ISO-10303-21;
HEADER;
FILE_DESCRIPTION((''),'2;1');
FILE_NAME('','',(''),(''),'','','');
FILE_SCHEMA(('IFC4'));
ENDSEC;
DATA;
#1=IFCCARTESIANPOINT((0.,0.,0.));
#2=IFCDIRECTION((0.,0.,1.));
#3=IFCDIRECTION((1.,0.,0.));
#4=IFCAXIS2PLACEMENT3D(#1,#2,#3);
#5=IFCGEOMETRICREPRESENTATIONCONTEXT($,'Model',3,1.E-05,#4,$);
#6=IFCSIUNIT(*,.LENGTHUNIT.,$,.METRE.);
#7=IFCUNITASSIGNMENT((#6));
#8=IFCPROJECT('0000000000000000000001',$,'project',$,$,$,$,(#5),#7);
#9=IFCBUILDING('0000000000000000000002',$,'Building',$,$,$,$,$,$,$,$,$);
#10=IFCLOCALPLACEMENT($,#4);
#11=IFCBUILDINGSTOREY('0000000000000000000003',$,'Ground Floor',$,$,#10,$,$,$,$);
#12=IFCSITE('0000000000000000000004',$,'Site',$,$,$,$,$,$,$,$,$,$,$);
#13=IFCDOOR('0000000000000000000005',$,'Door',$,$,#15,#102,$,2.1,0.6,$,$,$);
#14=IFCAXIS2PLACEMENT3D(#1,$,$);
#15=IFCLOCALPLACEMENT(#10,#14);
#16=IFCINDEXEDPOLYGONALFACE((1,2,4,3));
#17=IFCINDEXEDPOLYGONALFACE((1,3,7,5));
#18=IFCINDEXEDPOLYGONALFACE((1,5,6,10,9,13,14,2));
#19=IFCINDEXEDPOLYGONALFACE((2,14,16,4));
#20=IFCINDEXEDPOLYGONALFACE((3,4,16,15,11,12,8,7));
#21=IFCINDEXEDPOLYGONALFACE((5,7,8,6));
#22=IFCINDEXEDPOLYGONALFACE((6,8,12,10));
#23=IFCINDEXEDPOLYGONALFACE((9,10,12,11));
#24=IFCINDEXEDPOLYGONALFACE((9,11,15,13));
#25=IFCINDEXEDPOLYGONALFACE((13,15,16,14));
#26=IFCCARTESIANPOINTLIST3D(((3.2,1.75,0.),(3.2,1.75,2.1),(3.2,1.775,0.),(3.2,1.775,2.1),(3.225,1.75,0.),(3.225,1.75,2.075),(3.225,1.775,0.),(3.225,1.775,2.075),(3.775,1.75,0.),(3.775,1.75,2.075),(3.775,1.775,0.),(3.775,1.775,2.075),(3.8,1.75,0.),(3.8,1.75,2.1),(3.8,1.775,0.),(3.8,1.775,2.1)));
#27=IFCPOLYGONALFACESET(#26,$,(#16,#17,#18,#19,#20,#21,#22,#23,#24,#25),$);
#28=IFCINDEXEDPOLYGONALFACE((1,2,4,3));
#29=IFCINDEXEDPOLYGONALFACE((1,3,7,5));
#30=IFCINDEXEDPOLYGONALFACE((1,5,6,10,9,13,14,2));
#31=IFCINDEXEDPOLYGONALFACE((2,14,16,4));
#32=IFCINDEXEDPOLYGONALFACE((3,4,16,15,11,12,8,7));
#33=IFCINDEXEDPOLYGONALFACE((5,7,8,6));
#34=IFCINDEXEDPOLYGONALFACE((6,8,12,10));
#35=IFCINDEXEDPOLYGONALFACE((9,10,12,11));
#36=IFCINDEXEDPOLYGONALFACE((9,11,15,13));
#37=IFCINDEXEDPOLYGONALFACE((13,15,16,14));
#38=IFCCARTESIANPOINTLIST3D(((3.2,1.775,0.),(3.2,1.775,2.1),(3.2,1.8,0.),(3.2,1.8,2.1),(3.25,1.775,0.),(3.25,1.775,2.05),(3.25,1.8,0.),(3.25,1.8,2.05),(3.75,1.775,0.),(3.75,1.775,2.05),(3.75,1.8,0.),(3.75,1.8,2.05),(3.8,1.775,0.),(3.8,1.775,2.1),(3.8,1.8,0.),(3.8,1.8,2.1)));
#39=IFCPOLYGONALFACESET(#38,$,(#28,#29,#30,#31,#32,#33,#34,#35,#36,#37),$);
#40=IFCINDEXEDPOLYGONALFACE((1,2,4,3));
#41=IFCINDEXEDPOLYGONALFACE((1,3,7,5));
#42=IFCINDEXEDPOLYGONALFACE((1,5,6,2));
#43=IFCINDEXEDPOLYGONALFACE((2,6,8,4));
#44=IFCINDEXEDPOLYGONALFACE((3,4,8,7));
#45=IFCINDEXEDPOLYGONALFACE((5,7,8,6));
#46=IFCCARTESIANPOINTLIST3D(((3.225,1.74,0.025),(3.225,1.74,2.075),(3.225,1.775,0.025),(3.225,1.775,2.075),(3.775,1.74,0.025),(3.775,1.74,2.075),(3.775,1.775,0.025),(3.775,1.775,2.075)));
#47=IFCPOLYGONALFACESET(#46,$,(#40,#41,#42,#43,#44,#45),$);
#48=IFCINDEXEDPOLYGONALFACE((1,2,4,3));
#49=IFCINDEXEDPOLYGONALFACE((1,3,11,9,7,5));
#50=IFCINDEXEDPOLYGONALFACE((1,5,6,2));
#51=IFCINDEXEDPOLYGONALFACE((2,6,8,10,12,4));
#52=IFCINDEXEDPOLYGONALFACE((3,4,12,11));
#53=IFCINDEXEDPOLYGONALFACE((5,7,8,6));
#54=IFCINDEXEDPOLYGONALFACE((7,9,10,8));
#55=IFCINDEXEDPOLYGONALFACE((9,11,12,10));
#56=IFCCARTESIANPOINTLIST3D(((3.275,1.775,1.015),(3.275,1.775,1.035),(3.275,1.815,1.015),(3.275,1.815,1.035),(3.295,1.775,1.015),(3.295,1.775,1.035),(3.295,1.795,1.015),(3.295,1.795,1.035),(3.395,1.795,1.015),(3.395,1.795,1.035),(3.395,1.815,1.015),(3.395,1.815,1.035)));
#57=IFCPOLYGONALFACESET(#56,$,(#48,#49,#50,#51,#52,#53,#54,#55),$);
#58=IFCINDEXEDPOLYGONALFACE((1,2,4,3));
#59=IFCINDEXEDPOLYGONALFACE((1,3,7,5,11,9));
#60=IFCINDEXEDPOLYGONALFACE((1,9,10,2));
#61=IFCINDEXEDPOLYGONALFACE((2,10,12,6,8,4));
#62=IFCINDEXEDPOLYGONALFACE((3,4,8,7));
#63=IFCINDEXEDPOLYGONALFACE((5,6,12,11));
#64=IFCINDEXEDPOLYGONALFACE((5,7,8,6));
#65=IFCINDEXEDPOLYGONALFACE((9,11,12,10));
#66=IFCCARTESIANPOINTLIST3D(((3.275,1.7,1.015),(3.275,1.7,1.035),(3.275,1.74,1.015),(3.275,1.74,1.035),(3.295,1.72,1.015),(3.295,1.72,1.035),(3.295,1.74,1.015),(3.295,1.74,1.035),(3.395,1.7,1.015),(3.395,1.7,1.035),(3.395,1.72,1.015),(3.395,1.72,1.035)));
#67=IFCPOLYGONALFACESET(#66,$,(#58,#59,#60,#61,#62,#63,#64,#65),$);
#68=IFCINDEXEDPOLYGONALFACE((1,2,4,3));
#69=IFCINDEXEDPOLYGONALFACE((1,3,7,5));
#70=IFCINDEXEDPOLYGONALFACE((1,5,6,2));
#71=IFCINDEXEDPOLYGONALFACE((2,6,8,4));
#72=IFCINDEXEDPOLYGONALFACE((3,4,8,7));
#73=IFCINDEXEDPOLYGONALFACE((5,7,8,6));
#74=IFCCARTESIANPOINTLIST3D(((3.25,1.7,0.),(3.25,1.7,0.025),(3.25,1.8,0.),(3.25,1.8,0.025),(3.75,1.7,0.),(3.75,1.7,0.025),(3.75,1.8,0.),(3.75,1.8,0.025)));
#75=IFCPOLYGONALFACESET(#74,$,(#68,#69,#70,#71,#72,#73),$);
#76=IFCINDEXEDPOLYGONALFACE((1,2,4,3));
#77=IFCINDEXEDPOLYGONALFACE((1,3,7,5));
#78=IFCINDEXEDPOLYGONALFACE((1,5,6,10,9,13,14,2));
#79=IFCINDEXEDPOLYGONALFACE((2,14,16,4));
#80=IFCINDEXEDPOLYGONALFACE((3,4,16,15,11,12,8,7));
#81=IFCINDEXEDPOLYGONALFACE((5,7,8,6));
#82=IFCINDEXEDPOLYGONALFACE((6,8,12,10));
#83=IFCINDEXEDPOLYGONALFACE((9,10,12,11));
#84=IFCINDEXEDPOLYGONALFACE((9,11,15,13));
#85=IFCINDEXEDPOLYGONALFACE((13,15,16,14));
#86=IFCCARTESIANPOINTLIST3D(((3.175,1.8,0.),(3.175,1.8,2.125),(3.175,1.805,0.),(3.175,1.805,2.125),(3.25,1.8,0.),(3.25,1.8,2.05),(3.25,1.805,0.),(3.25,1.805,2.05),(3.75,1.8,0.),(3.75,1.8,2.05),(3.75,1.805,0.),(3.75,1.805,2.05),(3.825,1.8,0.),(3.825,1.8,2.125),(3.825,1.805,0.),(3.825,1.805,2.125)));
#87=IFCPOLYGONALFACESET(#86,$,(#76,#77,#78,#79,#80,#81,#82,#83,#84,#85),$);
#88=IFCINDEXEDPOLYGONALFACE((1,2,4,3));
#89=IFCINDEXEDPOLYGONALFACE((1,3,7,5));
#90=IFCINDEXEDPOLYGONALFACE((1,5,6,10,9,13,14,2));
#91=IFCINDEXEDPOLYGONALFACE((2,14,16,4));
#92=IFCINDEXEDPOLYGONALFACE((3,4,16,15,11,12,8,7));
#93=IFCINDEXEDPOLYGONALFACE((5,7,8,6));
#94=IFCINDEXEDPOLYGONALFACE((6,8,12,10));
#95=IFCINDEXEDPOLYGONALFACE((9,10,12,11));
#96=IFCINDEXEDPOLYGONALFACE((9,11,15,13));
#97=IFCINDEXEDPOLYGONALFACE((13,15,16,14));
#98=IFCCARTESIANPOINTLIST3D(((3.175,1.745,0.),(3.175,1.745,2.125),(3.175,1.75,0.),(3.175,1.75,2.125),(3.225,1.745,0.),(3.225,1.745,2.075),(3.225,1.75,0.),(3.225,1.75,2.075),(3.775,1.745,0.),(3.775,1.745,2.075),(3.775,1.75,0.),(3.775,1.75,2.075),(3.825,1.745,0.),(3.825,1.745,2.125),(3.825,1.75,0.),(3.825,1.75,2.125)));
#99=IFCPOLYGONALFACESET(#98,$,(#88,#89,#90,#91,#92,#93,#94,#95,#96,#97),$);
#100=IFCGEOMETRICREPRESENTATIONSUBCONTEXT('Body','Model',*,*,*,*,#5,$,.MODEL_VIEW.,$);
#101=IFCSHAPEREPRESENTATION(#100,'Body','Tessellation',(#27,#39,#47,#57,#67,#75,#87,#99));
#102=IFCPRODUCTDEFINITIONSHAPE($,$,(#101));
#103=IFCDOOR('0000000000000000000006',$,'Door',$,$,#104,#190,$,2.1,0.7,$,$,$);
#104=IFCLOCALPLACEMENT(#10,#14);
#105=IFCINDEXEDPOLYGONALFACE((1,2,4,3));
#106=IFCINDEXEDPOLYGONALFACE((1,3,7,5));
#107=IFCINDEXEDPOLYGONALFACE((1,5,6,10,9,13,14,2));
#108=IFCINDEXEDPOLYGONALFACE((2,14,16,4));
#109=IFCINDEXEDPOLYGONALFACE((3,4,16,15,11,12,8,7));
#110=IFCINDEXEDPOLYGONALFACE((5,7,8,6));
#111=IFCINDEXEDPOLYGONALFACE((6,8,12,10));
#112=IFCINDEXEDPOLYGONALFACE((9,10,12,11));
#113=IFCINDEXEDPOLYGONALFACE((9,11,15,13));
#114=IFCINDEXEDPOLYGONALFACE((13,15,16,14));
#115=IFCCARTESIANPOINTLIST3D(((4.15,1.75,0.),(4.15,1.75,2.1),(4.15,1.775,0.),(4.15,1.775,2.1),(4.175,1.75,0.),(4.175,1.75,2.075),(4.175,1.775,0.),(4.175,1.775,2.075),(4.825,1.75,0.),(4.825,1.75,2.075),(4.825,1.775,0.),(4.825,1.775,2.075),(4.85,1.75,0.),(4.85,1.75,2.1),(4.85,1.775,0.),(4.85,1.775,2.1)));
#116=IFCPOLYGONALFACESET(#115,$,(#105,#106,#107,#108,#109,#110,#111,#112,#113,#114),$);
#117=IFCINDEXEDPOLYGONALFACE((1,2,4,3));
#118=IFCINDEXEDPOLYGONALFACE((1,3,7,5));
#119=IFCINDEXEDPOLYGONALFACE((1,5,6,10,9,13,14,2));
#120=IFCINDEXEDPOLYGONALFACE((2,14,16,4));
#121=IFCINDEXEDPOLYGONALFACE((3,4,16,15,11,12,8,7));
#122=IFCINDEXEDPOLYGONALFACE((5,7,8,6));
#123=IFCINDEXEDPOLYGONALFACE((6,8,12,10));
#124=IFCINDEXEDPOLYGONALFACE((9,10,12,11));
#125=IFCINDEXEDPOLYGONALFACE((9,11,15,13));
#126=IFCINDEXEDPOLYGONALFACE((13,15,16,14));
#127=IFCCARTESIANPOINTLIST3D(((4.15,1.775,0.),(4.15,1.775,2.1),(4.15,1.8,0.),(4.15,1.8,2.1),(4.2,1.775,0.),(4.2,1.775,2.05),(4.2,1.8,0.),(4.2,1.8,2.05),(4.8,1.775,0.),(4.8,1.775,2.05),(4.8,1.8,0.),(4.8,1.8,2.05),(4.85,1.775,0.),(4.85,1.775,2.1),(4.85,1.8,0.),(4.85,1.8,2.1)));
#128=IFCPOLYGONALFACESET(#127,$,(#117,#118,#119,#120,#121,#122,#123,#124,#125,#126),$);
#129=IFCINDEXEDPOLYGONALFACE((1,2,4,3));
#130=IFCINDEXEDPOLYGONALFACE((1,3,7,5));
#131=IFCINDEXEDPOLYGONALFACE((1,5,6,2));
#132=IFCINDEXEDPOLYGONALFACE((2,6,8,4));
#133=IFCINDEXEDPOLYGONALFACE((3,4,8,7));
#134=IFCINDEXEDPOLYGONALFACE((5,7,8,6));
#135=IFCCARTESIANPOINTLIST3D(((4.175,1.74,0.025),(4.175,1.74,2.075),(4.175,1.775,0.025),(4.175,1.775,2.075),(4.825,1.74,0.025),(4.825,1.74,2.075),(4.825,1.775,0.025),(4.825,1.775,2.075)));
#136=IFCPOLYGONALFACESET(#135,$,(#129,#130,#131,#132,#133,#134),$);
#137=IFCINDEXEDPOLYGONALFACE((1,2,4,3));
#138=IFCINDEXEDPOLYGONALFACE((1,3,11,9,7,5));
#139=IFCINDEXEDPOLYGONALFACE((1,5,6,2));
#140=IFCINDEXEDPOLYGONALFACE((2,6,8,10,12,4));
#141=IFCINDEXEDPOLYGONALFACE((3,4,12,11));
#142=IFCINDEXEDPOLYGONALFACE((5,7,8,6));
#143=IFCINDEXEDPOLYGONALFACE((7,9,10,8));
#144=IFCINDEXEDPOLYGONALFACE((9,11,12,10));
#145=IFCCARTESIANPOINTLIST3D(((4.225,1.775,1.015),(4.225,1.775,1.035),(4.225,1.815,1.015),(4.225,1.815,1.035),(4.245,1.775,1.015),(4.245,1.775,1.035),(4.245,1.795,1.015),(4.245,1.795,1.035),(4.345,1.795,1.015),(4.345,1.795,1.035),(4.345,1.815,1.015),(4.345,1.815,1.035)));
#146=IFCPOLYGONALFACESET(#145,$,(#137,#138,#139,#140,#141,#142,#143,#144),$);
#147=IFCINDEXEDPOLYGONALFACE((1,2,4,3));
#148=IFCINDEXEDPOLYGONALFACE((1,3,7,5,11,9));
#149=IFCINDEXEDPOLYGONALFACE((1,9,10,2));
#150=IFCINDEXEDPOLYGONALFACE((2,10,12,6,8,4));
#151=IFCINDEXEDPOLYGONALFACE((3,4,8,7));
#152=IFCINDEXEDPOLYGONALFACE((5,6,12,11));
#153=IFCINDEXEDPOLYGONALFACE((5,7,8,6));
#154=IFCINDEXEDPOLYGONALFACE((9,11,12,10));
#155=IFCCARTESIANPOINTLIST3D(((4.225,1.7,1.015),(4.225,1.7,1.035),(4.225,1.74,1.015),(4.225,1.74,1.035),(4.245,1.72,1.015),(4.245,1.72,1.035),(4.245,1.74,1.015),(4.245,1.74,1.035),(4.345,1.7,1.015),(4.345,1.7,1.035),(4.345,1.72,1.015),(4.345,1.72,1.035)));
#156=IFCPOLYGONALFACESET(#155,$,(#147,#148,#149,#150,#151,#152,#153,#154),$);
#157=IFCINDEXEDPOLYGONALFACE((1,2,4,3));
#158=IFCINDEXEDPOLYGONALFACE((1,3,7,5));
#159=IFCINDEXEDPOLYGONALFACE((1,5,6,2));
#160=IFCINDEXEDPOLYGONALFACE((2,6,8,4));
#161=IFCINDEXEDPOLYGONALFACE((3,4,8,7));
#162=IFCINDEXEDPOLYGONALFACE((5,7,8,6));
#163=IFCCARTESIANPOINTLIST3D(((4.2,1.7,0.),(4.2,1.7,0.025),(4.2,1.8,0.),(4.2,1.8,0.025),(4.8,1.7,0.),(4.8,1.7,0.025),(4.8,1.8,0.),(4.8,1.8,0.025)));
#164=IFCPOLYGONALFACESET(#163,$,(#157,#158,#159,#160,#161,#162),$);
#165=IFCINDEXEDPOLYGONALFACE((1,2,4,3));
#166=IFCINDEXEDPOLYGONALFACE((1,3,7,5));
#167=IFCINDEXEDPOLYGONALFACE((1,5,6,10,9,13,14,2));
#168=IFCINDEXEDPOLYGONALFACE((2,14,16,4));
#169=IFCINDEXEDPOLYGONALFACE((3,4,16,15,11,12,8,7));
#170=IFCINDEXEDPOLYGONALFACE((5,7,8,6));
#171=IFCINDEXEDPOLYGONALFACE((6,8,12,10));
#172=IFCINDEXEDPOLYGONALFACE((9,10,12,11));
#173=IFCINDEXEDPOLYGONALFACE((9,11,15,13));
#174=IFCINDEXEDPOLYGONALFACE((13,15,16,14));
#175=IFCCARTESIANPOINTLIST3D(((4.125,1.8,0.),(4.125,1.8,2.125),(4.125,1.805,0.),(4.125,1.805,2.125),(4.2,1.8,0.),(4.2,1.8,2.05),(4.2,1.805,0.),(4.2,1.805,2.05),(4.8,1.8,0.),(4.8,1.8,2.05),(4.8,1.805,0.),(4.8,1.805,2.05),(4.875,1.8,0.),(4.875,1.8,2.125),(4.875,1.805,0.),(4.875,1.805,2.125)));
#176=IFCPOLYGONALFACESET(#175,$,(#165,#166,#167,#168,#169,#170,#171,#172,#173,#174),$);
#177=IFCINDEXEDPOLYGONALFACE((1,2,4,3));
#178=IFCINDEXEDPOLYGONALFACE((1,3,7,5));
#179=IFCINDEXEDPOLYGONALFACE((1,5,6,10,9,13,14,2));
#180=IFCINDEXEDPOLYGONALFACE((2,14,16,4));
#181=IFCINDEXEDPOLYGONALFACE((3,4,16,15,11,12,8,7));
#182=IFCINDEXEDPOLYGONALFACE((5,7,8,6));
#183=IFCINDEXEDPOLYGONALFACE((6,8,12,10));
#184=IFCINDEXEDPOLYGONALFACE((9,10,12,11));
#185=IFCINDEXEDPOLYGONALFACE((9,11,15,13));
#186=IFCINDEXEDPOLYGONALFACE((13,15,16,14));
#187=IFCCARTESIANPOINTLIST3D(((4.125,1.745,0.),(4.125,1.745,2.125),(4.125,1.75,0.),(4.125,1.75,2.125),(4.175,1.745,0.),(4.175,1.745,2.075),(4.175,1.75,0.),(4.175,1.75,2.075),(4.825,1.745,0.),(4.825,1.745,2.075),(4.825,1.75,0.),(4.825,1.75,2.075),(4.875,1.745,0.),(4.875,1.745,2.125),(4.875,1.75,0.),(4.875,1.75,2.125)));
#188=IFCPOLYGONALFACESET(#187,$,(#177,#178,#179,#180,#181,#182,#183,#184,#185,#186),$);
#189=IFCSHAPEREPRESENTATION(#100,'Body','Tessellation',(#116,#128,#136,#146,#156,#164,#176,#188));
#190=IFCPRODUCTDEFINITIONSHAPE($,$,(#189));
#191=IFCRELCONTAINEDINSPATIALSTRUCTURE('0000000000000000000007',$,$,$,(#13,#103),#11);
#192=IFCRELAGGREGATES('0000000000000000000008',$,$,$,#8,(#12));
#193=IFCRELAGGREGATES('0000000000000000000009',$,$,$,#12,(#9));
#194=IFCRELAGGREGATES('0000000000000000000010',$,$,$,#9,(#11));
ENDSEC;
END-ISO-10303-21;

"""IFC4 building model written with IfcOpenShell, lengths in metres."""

from ifc_helpers import new_model, si_unit, frame, origin_with_axes, place, context, subcontext, project, spatial, line, indexed_curve, outline, extrude, element, save


model = new_model("IFC4")

# Units and contexts
model_context = context("Model", 3, precision=1e-05, world=origin_with_axes())
body_context = subcontext(model_context, "Body", "Model", "MODEL_VIEW")
ifc_project = project(units=[si_unit("LENGTHUNIT", "METRE")], contexts=[model_context])

# Site, building, storey
site = spatial("IfcSite", under=ifc_project, Name="Site")
building = spatial("IfcBuilding", under=site, Name="Building")
storey_placement = place(None, origin_with_axes())
storey = spatial("IfcBuildingStorey", under=building, at=storey_placement, Name="Ground Floor")

# Doors
door_1_placement = place(storey_placement, frame((3.8, 1.8, 0.0), z_axis=(0.0, 0.0, 1.0), x_axis=(-1.0, 0.0, 0.0)))
element("IfcDoor", 1, at=door_1_placement, inside=storey, Name="Door", OverallHeight=2.1, OverallWidth=0.6, context=body_context, shape_type="SweptSolid", body=[
    extrude(outline(indexed_curve([(0.0, 0.0), (0.0, 2.1), (0.6, 2.1), (0.6, 0.0), (0.575, 0.0), (0.575, 2.075), (0.025, 2.075), (0.025, 0.0)], segments=[line(1, 2, 3, 4, 5, 6, 7, 8, 1)])), frame((0.0, 0.025, 0.0), z_axis=(0.0, -1.0, 0.0), x_axis=(1.0, 0.0, 0.0)), (0.0, 0.0, -1.0), 0.025),
    extrude(outline(indexed_curve([(0.0, 0.0), (0.0, 2.1), (0.6, 2.1), (0.6, 0.0), (0.55, 0.0), (0.55, 2.05), (0.05, 2.05), (0.05, 0.0)], segments=[line(1, 2, 3, 4, 5, 6, 7, 8, 1)])), frame((0.0, 0.0, 0.0), z_axis=(0.0, -1.0, 0.0), x_axis=(1.0, 0.0, 0.0)), (0.0, 0.0, -1.0), 0.025),
    extrude(outline(indexed_curve([(0.0, 0.0), (0.55, 0.0), (0.55, 0.035), (0.0, 0.035)], segments=[line(1, 2, 3, 4, 1)])), frame((0.025, 0.025, 0.025), z_axis=(0.0, 0.0, 1.0), x_axis=(1.0, 0.0, 0.0)), (0.0, 0.0, 1.0), 2.05),
    extrude(outline(indexed_curve([(0.0, 0.0), (0.0, -0.04), (-0.12, -0.04), (-0.12, -0.02), (-0.02, -0.02), (-0.02, 0.0)], segments=[line(1, 2, 3, 4, 5, 6, 1)])), frame((0.525, 0.025, 1.015), z_axis=(0.0, 0.0, 1.0), x_axis=(1.0, 0.0, 0.0)), (0.0, 0.0, 1.0), 0.02),
    extrude(outline(indexed_curve([(0.0, 0.0), (0.0, 0.04), (-0.12, 0.04), (-0.12, 0.02), (-0.02, 0.02), (-0.02, 0.0)], segments=[line(1, 2, 3, 4, 5, 6, 1)])), frame((0.525, 0.06, 1.015), z_axis=(0.0, 0.0, 1.0), x_axis=(1.0, 0.0, 0.0)), (0.0, 0.0, 1.0), 0.02),
    extrude(outline(indexed_curve([(0.0, 0.0), (0.5, 0.0), (0.5, 0.1), (0.0, 0.1)], segments=[line(1, 2, 3, 4, 1)])), frame((0.05, 0.0, 0.0), z_axis=(0.0, 0.0, 1.0), x_axis=(1.0, 0.0, 0.0)), (0.0, 0.0, 1.0), 0.025),
    extrude(outline(indexed_curve([(0.0, 0.0), (0.0, 2.125), (0.65, 2.125), (0.65, 0.0), (0.575, 0.0), (0.575, 2.05), (0.075, 2.05), (0.075, 0.0)], segments=[line(1, 2, 3, 4, 5, 6, 7, 8, 1)])), frame((-0.025, -0.005, 0.0), z_axis=(0.0, -1.0, 0.0), x_axis=(1.0, 0.0, 0.0)), (0.0, 0.0, -1.0), 0.005),
    extrude(outline(indexed_curve([(0.0, 0.0), (0.0, 2.125), (0.65, 2.125), (0.65, 0.0), (0.6, 0.0), (0.6, 2.075), (0.05, 2.075), (0.05, 0.0)], segments=[line(1, 2, 3, 4, 5, 6, 7, 8, 1)])), frame((-0.025, 0.05, 0.0), z_axis=(0.0, -1.0, 0.0), x_axis=(1.0, 0.0, 0.0)), (0.0, 0.0, -1.0), 0.005),
])
door_2_placement = place(storey_placement, frame((4.85, 1.8, 0.0), z_axis=(0.0, 0.0, 1.0), x_axis=(-1.0, 0.0, 0.0)))
element("IfcDoor", 2, at=door_2_placement, inside=storey, Name="Door", OverallHeight=2.1, OverallWidth=0.7, context=body_context, shape_type="SweptSolid", body=[
    extrude(outline(indexed_curve([(0.0, 0.0), (0.0, 2.1), (0.7, 2.1), (0.7, 0.0), (0.675, 0.0), (0.675, 2.075), (0.025, 2.075), (0.025, 0.0)], segments=[line(1, 2, 3, 4, 5, 6, 7, 8, 1)])), frame((0.0, 0.025, 0.0), z_axis=(0.0, -1.0, 0.0), x_axis=(1.0, 0.0, 0.0)), (0.0, 0.0, -1.0), 0.025),
    extrude(outline(indexed_curve([(0.0, 0.0), (0.0, 2.1), (0.7, 2.1), (0.7, 0.0), (0.65, 0.0), (0.65, 2.05), (0.05, 2.05), (0.05, 0.0)], segments=[line(1, 2, 3, 4, 5, 6, 7, 8, 1)])), frame((0.0, 0.0, 0.0), z_axis=(0.0, -1.0, 0.0), x_axis=(1.0, 0.0, 0.0)), (0.0, 0.0, -1.0), 0.025),
    extrude(outline(indexed_curve([(0.0, 0.0), (0.65, 0.0), (0.65, 0.035), (0.0, 0.035)], segments=[line(1, 2, 3, 4, 1)])), frame((0.025, 0.025, 0.025), z_axis=(0.0, 0.0, 1.0), x_axis=(1.0, 0.0, 0.0)), (0.0, 0.0, 1.0), 2.05),
    extrude(outline(indexed_curve([(0.0, 0.0), (0.0, -0.04), (-0.12, -0.04), (-0.12, -0.02), (-0.02, -0.02), (-0.02, 0.0)], segments=[line(1, 2, 3, 4, 5, 6, 1)])), frame((0.625, 0.025, 1.015), z_axis=(0.0, 0.0, 1.0), x_axis=(1.0, 0.0, 0.0)), (0.0, 0.0, 1.0), 0.02),
    extrude(outline(indexed_curve([(0.0, 0.0), (0.0, 0.04), (-0.12, 0.04), (-0.12, 0.02), (-0.02, 0.02), (-0.02, 0.0)], segments=[line(1, 2, 3, 4, 5, 6, 1)])), frame((0.625, 0.06, 1.015), z_axis=(0.0, 0.0, 1.0), x_axis=(1.0, 0.0, 0.0)), (0.0, 0.0, 1.0), 0.02),
    extrude(outline(indexed_curve([(0.0, 0.0), (0.6, 0.0), (0.6, 0.1), (0.0, 0.1)], segments=[line(1, 2, 3, 4, 1)])), frame((0.05, 0.0, 0.0), z_axis=(0.0, 0.0, 1.0), x_axis=(1.0, 0.0, 0.0)), (0.0, 0.0, 1.0), 0.025),
    extrude(outline(indexed_curve([(0.0, 0.0), (0.0, 2.125), (0.75, 2.125), (0.75, 0.0), (0.675, 0.0), (0.675, 2.05), (0.075, 2.05), (0.075, 0.0)], segments=[line(1, 2, 3, 4, 5, 6, 7, 8, 1)])), frame((-0.025, -0.005, 0.0), z_axis=(0.0, -1.0, 0.0), x_axis=(1.0, 0.0, 0.0)), (0.0, 0.0, -1.0), 0.005),
    extrude(outline(indexed_curve([(0.0, 0.0), (0.0, 2.125), (0.75, 2.125), (0.75, 0.0), (0.7, 0.0), (0.7, 2.075), (0.05, 2.075), (0.05, 0.0)], segments=[line(1, 2, 3, 4, 5, 6, 7, 8, 1)])), frame((-0.025, 0.05, 0.0), z_axis=(0.0, -1.0, 0.0), x_axis=(1.0, 0.0, 0.0)), (0.0, 0.0, -1.0), 0.005),
])

save(model, "model.ifc")
